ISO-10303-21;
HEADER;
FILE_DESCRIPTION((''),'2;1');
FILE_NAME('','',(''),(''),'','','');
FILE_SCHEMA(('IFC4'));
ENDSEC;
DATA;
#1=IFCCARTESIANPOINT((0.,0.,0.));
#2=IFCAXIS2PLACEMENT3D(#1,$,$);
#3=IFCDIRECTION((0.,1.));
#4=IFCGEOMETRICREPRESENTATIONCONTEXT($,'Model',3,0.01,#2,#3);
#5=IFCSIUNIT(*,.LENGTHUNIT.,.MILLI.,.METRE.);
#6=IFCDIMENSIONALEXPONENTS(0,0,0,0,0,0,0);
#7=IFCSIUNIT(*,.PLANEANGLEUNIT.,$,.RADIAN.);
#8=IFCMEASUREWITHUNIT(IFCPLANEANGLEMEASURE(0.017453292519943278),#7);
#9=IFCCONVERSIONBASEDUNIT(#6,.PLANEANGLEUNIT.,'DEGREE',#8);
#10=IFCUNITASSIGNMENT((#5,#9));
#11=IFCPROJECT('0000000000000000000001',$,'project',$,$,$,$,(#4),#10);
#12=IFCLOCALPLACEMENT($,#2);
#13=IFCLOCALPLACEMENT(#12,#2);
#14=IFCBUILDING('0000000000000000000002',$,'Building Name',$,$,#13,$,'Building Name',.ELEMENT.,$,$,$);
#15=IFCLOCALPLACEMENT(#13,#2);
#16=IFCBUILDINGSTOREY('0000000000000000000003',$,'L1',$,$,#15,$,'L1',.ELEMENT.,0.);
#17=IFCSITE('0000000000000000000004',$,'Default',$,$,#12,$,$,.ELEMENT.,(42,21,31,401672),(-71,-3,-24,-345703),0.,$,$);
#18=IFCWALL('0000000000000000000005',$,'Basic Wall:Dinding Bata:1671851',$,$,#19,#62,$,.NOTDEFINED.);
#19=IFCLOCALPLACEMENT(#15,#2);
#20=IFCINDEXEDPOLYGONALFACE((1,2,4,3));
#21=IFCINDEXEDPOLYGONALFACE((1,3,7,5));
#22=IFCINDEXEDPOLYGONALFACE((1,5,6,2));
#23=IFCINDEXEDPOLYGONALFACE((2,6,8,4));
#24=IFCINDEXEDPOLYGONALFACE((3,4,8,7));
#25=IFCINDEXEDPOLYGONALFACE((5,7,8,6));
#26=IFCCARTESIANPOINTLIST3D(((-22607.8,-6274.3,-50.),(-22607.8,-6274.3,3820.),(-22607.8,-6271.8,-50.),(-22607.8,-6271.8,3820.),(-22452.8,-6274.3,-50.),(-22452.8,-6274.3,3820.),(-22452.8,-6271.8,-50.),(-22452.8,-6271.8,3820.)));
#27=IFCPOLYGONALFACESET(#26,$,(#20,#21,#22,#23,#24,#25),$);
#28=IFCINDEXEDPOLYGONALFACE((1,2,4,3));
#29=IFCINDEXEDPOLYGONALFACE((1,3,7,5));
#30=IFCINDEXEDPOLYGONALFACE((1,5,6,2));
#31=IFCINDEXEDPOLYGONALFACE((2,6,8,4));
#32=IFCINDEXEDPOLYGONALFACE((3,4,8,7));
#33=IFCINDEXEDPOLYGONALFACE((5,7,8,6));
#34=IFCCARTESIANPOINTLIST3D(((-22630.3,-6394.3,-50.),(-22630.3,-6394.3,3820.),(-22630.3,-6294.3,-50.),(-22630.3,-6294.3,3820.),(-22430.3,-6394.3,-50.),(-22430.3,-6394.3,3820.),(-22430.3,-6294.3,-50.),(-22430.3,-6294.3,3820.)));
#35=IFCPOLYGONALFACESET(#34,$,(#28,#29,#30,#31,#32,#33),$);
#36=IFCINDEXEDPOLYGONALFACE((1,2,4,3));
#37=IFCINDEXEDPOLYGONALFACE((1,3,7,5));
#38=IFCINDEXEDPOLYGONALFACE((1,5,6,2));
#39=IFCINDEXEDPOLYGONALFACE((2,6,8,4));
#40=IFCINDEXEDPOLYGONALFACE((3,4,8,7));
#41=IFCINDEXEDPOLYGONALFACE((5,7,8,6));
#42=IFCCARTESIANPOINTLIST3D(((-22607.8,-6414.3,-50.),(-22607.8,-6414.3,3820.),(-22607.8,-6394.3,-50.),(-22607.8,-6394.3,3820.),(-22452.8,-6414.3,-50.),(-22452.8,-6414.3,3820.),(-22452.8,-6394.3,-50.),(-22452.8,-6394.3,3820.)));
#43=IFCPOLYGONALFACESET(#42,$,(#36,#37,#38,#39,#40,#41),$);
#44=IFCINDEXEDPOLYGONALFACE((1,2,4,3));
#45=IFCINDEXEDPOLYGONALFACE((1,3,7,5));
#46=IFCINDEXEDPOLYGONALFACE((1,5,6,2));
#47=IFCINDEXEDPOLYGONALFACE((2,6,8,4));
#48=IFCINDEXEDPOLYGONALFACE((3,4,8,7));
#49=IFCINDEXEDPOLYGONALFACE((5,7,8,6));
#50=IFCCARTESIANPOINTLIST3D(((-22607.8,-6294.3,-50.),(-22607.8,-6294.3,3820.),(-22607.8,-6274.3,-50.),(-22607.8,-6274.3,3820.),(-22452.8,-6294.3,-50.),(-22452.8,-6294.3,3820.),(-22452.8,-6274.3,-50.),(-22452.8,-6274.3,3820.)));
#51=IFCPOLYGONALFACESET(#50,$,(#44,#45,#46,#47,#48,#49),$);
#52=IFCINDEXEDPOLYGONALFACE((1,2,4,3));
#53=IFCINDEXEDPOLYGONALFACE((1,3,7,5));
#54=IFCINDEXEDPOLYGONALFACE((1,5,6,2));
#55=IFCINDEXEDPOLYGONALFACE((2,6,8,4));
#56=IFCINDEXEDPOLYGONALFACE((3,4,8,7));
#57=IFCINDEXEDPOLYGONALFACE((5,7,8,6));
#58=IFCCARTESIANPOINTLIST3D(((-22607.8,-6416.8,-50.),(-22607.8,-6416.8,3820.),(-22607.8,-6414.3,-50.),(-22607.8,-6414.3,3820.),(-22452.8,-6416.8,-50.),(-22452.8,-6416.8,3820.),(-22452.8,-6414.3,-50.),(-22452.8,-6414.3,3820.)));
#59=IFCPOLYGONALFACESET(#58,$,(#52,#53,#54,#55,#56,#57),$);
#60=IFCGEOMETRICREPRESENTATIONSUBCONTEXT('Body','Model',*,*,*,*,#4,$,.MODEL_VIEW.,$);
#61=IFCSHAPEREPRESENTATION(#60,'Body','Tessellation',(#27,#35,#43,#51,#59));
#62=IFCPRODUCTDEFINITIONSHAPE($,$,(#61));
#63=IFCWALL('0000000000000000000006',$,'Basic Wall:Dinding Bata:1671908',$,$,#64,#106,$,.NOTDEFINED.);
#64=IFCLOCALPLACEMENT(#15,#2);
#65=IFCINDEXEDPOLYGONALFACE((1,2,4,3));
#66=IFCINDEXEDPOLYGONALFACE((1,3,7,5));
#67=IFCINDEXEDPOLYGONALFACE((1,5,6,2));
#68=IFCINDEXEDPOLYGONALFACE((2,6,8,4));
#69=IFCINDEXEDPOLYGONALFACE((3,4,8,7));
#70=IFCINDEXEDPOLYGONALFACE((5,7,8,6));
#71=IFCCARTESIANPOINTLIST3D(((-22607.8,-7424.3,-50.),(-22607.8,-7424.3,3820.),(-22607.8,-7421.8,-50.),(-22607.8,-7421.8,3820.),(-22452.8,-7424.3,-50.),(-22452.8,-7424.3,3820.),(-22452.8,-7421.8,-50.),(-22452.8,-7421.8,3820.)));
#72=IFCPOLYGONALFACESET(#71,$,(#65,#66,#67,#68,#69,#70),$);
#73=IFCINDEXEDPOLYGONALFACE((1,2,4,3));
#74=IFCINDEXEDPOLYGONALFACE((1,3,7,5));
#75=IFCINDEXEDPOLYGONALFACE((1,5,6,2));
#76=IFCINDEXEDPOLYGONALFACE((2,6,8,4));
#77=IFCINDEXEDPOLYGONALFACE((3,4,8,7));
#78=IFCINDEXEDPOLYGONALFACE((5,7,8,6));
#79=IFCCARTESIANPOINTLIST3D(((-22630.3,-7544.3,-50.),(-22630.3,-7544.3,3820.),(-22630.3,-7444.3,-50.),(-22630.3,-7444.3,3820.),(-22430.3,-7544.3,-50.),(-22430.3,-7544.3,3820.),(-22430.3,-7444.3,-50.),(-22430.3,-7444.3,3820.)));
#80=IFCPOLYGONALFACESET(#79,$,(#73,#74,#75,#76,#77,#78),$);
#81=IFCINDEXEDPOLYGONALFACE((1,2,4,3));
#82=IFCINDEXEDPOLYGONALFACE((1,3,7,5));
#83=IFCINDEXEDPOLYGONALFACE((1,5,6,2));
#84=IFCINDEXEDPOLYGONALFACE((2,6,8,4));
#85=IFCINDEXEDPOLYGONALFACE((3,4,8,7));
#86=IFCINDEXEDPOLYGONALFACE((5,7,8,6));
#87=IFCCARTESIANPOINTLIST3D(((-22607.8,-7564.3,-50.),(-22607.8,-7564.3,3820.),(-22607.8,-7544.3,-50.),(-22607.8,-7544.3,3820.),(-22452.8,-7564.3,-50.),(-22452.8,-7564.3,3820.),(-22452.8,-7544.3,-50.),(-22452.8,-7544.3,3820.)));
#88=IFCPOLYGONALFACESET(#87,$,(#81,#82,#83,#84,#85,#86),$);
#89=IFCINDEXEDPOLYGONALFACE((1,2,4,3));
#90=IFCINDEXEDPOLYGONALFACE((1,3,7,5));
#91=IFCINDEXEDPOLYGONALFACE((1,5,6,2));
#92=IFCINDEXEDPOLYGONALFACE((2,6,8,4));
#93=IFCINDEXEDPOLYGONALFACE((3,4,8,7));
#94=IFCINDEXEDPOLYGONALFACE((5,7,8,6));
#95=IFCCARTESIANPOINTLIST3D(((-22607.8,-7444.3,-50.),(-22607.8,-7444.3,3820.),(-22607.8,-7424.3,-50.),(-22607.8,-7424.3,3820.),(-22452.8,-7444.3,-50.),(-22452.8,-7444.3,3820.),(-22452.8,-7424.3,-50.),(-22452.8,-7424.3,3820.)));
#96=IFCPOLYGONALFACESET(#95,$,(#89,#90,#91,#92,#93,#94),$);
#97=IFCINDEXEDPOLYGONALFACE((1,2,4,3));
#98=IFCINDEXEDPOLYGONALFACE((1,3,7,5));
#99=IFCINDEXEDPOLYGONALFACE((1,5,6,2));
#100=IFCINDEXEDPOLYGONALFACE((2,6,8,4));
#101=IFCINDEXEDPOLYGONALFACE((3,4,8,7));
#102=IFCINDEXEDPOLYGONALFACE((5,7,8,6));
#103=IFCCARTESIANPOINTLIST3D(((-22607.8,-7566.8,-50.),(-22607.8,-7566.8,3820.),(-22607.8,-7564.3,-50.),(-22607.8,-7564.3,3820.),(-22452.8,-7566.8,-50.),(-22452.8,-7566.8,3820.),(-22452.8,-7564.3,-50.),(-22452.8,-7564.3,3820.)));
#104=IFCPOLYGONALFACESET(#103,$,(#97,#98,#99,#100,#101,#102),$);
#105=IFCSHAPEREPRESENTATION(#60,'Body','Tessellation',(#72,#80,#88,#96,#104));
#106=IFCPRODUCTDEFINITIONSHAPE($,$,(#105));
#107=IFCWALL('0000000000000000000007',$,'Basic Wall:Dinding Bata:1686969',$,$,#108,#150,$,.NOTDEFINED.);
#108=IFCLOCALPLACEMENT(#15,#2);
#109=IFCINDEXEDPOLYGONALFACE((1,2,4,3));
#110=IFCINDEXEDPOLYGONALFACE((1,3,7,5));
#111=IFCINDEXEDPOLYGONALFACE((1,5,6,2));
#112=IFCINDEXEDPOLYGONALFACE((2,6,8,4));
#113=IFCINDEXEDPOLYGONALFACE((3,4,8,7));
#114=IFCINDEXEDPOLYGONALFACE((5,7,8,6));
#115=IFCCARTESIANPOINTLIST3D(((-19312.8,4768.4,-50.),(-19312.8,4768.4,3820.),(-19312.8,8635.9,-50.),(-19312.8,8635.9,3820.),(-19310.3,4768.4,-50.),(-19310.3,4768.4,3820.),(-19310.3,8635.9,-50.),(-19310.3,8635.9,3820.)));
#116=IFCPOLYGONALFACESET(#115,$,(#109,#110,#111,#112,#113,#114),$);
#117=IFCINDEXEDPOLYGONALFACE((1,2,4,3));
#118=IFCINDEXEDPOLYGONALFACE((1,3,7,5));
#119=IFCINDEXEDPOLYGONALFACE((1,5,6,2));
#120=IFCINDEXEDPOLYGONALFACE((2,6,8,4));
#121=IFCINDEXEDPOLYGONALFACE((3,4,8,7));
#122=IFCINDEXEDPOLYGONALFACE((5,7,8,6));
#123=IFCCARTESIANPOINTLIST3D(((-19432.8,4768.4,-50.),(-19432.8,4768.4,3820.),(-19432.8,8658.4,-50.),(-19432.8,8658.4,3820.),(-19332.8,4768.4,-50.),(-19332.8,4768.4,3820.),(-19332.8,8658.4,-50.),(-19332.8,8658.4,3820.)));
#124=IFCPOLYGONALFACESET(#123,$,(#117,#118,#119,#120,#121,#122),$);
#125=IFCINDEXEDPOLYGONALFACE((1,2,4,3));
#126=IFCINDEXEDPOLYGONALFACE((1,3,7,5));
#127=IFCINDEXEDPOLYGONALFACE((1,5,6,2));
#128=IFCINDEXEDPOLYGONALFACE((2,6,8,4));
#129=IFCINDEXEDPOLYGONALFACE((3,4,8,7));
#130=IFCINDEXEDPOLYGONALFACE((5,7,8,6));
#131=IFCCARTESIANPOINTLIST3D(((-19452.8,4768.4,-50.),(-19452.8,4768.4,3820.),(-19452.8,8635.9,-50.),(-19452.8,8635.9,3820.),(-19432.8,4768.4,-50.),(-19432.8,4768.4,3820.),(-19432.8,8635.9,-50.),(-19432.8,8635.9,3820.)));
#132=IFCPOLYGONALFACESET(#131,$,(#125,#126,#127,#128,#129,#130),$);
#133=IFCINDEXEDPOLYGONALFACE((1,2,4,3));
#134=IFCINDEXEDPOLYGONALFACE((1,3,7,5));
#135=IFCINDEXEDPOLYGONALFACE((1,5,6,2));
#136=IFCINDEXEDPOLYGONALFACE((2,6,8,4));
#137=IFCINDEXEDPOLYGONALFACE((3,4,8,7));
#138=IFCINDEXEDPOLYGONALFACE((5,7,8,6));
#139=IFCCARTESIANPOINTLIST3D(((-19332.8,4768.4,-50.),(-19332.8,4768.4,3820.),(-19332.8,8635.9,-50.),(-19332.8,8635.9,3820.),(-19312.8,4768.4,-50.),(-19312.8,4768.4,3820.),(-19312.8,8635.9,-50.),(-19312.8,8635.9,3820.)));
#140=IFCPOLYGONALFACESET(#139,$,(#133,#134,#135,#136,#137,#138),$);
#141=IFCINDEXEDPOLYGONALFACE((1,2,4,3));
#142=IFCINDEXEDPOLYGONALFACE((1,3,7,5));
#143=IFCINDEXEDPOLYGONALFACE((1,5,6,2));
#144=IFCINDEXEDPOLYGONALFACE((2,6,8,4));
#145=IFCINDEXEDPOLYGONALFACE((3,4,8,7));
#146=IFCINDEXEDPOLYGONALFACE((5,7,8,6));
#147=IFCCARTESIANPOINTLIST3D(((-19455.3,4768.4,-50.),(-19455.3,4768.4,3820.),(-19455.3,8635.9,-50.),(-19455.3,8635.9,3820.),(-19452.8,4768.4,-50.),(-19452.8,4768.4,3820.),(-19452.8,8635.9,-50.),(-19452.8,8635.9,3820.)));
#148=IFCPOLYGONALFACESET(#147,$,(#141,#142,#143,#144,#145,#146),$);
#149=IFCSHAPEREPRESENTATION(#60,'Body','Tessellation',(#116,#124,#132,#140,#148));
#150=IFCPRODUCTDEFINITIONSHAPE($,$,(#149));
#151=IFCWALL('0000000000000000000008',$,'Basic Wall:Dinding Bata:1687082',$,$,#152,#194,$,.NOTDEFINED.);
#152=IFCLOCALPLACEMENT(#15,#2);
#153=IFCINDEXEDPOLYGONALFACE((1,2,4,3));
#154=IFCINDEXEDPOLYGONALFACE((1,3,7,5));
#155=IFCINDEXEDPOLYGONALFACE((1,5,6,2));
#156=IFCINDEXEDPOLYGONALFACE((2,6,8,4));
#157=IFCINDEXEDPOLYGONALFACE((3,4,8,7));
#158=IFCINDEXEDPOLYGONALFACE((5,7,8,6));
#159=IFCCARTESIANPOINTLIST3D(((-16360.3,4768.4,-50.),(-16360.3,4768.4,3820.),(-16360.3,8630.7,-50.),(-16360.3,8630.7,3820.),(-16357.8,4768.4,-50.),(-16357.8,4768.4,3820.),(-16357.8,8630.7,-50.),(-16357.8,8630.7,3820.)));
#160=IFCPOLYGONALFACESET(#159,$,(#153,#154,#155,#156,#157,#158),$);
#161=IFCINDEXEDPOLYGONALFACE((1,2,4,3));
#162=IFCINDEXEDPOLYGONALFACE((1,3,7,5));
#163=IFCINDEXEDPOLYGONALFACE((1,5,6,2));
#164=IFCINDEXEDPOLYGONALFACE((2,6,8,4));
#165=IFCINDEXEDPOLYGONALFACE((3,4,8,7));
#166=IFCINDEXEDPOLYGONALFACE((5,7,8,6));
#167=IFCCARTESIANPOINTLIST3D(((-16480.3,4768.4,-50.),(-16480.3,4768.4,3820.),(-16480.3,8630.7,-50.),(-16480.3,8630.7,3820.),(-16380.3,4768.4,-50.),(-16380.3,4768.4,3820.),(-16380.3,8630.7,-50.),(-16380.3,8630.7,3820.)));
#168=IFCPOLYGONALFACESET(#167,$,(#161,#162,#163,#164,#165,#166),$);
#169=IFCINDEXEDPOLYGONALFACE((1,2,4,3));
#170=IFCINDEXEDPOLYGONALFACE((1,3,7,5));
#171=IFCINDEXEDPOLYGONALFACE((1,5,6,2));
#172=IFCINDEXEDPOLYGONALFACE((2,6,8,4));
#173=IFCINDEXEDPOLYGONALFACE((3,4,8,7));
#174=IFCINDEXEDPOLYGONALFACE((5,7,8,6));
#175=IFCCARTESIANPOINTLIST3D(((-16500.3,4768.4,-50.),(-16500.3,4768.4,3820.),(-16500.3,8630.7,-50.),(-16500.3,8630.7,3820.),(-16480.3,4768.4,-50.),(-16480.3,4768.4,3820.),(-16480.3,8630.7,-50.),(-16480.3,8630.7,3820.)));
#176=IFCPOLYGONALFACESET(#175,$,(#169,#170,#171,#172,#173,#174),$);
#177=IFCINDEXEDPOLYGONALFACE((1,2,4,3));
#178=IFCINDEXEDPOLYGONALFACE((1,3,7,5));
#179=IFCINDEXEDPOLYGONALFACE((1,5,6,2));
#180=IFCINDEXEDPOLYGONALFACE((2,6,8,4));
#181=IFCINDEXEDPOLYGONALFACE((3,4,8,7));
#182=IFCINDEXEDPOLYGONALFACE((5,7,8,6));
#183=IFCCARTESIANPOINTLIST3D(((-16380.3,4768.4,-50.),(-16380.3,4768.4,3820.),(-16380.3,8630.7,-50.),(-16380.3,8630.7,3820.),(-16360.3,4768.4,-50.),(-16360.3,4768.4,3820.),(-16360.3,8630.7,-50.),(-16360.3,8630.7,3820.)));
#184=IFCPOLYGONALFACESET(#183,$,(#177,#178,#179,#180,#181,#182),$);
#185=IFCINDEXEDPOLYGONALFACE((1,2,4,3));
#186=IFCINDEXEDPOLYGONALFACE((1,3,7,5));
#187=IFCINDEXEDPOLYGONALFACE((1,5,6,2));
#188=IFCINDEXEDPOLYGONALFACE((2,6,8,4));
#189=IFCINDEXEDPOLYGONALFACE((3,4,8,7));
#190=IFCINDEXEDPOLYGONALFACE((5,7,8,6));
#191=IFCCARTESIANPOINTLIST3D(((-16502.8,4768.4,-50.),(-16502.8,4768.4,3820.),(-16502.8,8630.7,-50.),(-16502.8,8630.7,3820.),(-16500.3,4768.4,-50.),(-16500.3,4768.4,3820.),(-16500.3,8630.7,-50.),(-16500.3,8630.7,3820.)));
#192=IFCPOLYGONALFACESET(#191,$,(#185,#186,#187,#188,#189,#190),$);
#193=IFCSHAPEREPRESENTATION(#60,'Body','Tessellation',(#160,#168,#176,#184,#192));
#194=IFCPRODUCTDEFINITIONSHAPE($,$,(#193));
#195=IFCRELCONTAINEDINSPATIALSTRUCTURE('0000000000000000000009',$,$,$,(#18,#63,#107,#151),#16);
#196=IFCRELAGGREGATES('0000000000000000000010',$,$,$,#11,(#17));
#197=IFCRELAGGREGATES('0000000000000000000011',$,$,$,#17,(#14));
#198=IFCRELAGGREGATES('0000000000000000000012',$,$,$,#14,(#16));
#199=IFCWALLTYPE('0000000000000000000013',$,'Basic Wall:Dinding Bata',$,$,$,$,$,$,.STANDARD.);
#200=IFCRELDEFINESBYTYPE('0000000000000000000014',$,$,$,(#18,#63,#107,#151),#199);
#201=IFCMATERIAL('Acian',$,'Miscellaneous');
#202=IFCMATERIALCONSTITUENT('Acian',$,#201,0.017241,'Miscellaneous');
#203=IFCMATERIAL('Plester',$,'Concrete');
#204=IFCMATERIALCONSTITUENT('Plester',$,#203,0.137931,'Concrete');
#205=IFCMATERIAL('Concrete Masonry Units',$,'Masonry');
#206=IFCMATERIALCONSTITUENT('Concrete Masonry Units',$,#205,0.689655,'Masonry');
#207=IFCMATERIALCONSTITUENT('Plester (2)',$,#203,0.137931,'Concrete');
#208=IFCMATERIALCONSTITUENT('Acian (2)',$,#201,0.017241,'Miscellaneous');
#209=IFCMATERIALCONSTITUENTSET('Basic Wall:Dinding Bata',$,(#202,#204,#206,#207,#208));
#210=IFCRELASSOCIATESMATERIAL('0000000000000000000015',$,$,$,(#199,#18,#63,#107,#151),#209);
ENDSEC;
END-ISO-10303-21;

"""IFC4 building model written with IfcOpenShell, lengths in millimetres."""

from ifc_helpers import new_model, entity, si_unit, converted_unit, direction, frame, origin, place, context, subcontext, project, spatial, indexed_curve, outline, extrude, material, constituent, constituent_set, type_object, element, save


model = new_model("IFC4")

# Units and contexts
model_context = context("Model", 3, precision=0.01, world=origin(), true_north=direction((0.0, 1.0)))
body_context = subcontext(model_context, "Body", "Model", "MODEL_VIEW")
ifc_project = project(units=[si_unit("LENGTHUNIT", "METRE", prefix="MILLI"), converted_unit("PLANEANGLEUNIT", "DEGREE", entity("IfcPlaneAngleMeasure", 0.017453292519943278), si_unit("PLANEANGLEUNIT", "RADIAN"), dimensions=[0, 0, 0, 0, 0, 0, 0])], contexts=[model_context])

# Site, building, storey
site_placement = place(None, origin())
site = spatial("IfcSite", under=ifc_project, at=site_placement, Name="Default", CompositionType="ELEMENT", RefLatitude=(42, 21, 31, 401672), RefLongitude=(-71, -3, -24, -345703), RefElevation=0.0)
building_placement = place(site_placement, origin())
building = spatial("IfcBuilding", under=site, at=building_placement, Name="Building Name", LongName="Building Name", CompositionType="ELEMENT")
storey_placement = place(building_placement, origin())
storey = spatial("IfcBuildingStorey", under=building, at=storey_placement, Name="L1", LongName="L1", CompositionType="ELEMENT", Elevation=0.0)

# Walls
ifc_material_1 = material(Name="Acian", Category="Miscellaneous")
ifc_constituent_1 = constituent(ifc_material_1, Name="Acian", Category="Miscellaneous", fraction=0.017241)
ifc_material_2 = material(Name="Plester", Category="Concrete")
ifc_constituent_2 = constituent(ifc_material_2, Name="Plester", Category="Concrete", fraction=0.137931)
ifc_material_3 = material(Name="Concrete Masonry Units", Category="Masonry")
ifc_constituent_3 = constituent(ifc_material_3, Name="Concrete Masonry Units", Category="Masonry", fraction=0.689655)
ifc_constituent_4 = constituent(ifc_material_2, Name="Plester (2)", Category="Concrete", fraction=0.137931)
ifc_constituent_5 = constituent(ifc_material_1, Name="Acian (2)", Category="Miscellaneous", fraction=0.017241)
ifc_constituent_set = constituent_set(constituents=[ifc_constituent_1, ifc_constituent_2, ifc_constituent_3, ifc_constituent_4, ifc_constituent_5], Name="Basic Wall:Dinding Bata")
wall_type = type_object("IfcWallType", Name="Basic Wall:Dinding Bata", PredefinedType="STANDARD", material=ifc_constituent_set)
wall_1_placement = place(storey_placement, frame((-22607.8, -6344.3, -50.0)))
element("IfcWall", 1, at=wall_1_placement, inside=storey, type_object=wall_type, material=ifc_constituent_set, Name="Basic Wall:Dinding Bata:1671851", PredefinedType="NOTDEFINED", context=body_context, shape_type="SweptSolid", body=[
    extrude(outline(indexed_curve([(-1.2, -77.5), (1.2, -77.5), (1.2, 77.5), (-1.2, 77.5), (-1.2, -77.5)], self_intersect=False)), frame((77.5, 71.3, 0.0), z_axis=(0.0, 0.0, 1.0), x_axis=(0.0, -1.0, 0.0)), (0.0, 0.0, 1.0), 3870.0),
    extrude(outline(indexed_curve([(-100.0, -50.0), (100.0, -50.0), (100.0, 50.0), (-100.0, 50.0), (-100.0, -50.0)], self_intersect=False)), frame((77.5, 0.0, 0.0)), (0.0, 0.0, 1.0), 3870.0),
    extrude(outline(indexed_curve([(-77.5, -10.0), (77.5, -10.0), (77.5, 10.0), (-77.5, 10.0), (-77.5, -10.0)], self_intersect=False)), frame((77.5, -60.0, 0.0)), (0.0, 0.0, 1.0), 3870.0),
    extrude(outline(indexed_curve([(-77.5, -10.0), (77.5, -10.0), (77.5, 10.0), (-77.5, 10.0), (-77.5, -10.0)], self_intersect=False)), frame((77.5, 60.0, 0.0)), (0.0, 0.0, 1.0), 3870.0),
    extrude(outline(indexed_curve([(-1.2, -77.5), (1.2, -77.5), (1.2, 77.5), (-1.2, 77.5), (-1.2, -77.5)], self_intersect=False)), frame((77.5, -71.3, 0.0), z_axis=(0.0, 0.0, 1.0), x_axis=(0.0, 1.0, 0.0)), (0.0, 0.0, 1.0), 3870.0),
])
wall_2_placement = place(storey_placement, frame((-22607.8, -7494.3, -50.0)))
element("IfcWall", 2, at=wall_2_placement, inside=storey, type_object=wall_type, material=ifc_constituent_set, Name="Basic Wall:Dinding Bata:1671908", PredefinedType="NOTDEFINED", context=body_context, shape_type="SweptSolid", body=[
    extrude(outline(indexed_curve([(-1.3, -77.5), (1.2, -77.5), (1.2, 77.5), (-1.2, 77.5), (-1.3, -77.5)], self_intersect=False)), frame((77.5, 71.2, 0.0), z_axis=(0.0, 0.0, 1.0), x_axis=(0.0, -1.0, 0.0)), (0.0, 0.0, 1.0), 3870.0),
    extrude(outline(indexed_curve([(-100.0, -50.0), (100.0, -50.0), (100.0, 50.0), (-100.0, 50.0), (-100.0, -50.0)], self_intersect=False)), frame((77.5, 0.0, 0.0)), (0.0, 0.0, 1.0), 3870.0),
    extrude(outline(indexed_curve([(-77.5, -10.0), (77.5, -10.0), (77.5, 10.0), (-77.5, 10.0), (-77.5, -10.0)], self_intersect=False)), frame((77.5, -60.0, 0.0)), (0.0, 0.0, 1.0), 3870.0),
    extrude(outline(indexed_curve([(-77.5, -10.0), (77.5, -10.0), (77.5, 10.0), (-77.5, 10.0), (-77.5, -10.0)], self_intersect=False)), frame((77.5, 60.0, 0.0)), (0.0, 0.0, 1.0), 3870.0),
    extrude(outline(indexed_curve([(-1.2, -77.5), (1.2, -77.5), (1.3, 77.5), (-1.2, 77.5), (-1.2, -77.5)], self_intersect=False)), frame((77.5, -71.3, 0.0), z_axis=(0.0, 0.0, 1.0), x_axis=(0.0, 1.0, 0.0)), (0.0, 0.0, 1.0), 3870.0),
])
wall_3_placement = place(storey_placement, frame((-19382.8, 8635.9, -50.0), z_axis=(0.0, 0.0, 1.0), x_axis=(0.0, -1.0, 0.0)))
element("IfcWall", 3, at=wall_3_placement, inside=storey, type_object=wall_type, material=ifc_constituent_set, Name="Basic Wall:Dinding Bata:1686969", PredefinedType="NOTDEFINED", context=body_context, shape_type="SweptSolid", body=[
    extrude(outline(indexed_curve([(-1.3, -1933.8), (1.2, -1933.8), (1.3, 1933.8), (-1.2, 1933.8), (-1.3, -1933.8)], self_intersect=False)), frame((1933.8, 71.3, 0.0), z_axis=(0.0, 0.0, 1.0), x_axis=(0.0, -1.0, 0.0)), (0.0, 0.0, 1.0), 3870.0),
    extrude(outline(indexed_curve([(-1945.0, -50.0), (1945.0, -50.0), (1945.0, 50.0), (-1945.0, 50.0), (-1945.0, -50.0)], self_intersect=False)), frame((1922.5, 0.0, 0.0)), (0.0, 0.0, 1.0), 3870.0),
    extrude(outline(indexed_curve([(-1933.8, -10.0), (1933.8, -10.0), (1933.8, 10.0), (-1933.8, 10.0), (-1933.8, -10.0)], self_intersect=False)), frame((1933.8, -60.0, 0.0)), (0.0, 0.0, 1.0), 3870.0),
    extrude(outline(indexed_curve([(-1933.8, -10.0), (1933.8, -10.0), (1933.8, 10.0), (-1933.8, 10.0), (-1933.8, -10.0)], self_intersect=False)), frame((1933.8, 60.0, 0.0)), (0.0, 0.0, 1.0), 3870.0),
    extrude(outline(indexed_curve([(-1.3, -1933.8), (1.2, -1933.8), (1.3, 1933.8), (-1.2, 1933.8), (-1.3, -1933.8)], self_intersect=False)), frame((1933.8, -71.2, 0.0), z_axis=(0.0, 0.0, 1.0), x_axis=(0.0, 1.0, 0.0)), (0.0, 0.0, 1.0), 3870.0),
])
wall_4_placement = place(storey_placement, frame((-16430.3, 8630.7, -50.0), z_axis=(0.0, 0.0, 1.0), x_axis=(0.0, -1.0, 0.0)))
element("IfcWall", 4, at=wall_4_placement, inside=storey, type_object=wall_type, material=ifc_constituent_set, Name="Basic Wall:Dinding Bata:1687082", PredefinedType="NOTDEFINED", context=body_context, shape_type="SweptSolid", body=[
    extrude(outline(indexed_curve([(-1.3, -1931.2), (1.2, -1931.2), (1.3, 1931.2), (-1.2, 1931.2), (-1.3, -1931.2)], self_intersect=False)), frame((1931.2, 71.2, 0.0), z_axis=(0.0, 0.0, 1.0), x_axis=(0.0, -1.0, 0.0)), (0.0, 0.0, 1.0), 3870.0),
    extrude(outline(indexed_curve([(-1931.2, -50.0), (1931.2, -50.0), (1931.2, 50.0), (-1931.2, 50.0), (-1931.2, -50.0)], self_intersect=False)), frame((1931.2, 0.0, 0.0)), (0.0, 0.0, 1.0), 3870.0),
    extrude(outline(indexed_curve([(-1931.2, -10.0), (1931.2, -10.0), (1931.2, 10.0), (-1931.2, 10.0), (-1931.2, -10.0)], self_intersect=False)), frame((1931.2, -60.0, 0.0)), (0.0, 0.0, 1.0), 3870.0),
    extrude(outline(indexed_curve([(-1931.2, -10.0), (1931.2, -10.0), (1931.2, 10.0), (-1931.2, 10.0), (-1931.2, -10.0)], self_intersect=False)), frame((1931.2, 60.0, 0.0)), (0.0, 0.0, 1.0), 3870.0),
    extrude(outline(indexed_curve([(-1.3, -1931.2), (1.2, -1931.2), (1.3, 1931.2), (-1.2, 1931.2), (-1.3, -1931.2)], self_intersect=False)), frame((1931.2, -71.2, 0.0), z_axis=(0.0, 0.0, 1.0), x_axis=(0.0, 1.0, 0.0)), (0.0, 0.0, 1.0), 3870.0),
])

save(model, "model.ifc")
